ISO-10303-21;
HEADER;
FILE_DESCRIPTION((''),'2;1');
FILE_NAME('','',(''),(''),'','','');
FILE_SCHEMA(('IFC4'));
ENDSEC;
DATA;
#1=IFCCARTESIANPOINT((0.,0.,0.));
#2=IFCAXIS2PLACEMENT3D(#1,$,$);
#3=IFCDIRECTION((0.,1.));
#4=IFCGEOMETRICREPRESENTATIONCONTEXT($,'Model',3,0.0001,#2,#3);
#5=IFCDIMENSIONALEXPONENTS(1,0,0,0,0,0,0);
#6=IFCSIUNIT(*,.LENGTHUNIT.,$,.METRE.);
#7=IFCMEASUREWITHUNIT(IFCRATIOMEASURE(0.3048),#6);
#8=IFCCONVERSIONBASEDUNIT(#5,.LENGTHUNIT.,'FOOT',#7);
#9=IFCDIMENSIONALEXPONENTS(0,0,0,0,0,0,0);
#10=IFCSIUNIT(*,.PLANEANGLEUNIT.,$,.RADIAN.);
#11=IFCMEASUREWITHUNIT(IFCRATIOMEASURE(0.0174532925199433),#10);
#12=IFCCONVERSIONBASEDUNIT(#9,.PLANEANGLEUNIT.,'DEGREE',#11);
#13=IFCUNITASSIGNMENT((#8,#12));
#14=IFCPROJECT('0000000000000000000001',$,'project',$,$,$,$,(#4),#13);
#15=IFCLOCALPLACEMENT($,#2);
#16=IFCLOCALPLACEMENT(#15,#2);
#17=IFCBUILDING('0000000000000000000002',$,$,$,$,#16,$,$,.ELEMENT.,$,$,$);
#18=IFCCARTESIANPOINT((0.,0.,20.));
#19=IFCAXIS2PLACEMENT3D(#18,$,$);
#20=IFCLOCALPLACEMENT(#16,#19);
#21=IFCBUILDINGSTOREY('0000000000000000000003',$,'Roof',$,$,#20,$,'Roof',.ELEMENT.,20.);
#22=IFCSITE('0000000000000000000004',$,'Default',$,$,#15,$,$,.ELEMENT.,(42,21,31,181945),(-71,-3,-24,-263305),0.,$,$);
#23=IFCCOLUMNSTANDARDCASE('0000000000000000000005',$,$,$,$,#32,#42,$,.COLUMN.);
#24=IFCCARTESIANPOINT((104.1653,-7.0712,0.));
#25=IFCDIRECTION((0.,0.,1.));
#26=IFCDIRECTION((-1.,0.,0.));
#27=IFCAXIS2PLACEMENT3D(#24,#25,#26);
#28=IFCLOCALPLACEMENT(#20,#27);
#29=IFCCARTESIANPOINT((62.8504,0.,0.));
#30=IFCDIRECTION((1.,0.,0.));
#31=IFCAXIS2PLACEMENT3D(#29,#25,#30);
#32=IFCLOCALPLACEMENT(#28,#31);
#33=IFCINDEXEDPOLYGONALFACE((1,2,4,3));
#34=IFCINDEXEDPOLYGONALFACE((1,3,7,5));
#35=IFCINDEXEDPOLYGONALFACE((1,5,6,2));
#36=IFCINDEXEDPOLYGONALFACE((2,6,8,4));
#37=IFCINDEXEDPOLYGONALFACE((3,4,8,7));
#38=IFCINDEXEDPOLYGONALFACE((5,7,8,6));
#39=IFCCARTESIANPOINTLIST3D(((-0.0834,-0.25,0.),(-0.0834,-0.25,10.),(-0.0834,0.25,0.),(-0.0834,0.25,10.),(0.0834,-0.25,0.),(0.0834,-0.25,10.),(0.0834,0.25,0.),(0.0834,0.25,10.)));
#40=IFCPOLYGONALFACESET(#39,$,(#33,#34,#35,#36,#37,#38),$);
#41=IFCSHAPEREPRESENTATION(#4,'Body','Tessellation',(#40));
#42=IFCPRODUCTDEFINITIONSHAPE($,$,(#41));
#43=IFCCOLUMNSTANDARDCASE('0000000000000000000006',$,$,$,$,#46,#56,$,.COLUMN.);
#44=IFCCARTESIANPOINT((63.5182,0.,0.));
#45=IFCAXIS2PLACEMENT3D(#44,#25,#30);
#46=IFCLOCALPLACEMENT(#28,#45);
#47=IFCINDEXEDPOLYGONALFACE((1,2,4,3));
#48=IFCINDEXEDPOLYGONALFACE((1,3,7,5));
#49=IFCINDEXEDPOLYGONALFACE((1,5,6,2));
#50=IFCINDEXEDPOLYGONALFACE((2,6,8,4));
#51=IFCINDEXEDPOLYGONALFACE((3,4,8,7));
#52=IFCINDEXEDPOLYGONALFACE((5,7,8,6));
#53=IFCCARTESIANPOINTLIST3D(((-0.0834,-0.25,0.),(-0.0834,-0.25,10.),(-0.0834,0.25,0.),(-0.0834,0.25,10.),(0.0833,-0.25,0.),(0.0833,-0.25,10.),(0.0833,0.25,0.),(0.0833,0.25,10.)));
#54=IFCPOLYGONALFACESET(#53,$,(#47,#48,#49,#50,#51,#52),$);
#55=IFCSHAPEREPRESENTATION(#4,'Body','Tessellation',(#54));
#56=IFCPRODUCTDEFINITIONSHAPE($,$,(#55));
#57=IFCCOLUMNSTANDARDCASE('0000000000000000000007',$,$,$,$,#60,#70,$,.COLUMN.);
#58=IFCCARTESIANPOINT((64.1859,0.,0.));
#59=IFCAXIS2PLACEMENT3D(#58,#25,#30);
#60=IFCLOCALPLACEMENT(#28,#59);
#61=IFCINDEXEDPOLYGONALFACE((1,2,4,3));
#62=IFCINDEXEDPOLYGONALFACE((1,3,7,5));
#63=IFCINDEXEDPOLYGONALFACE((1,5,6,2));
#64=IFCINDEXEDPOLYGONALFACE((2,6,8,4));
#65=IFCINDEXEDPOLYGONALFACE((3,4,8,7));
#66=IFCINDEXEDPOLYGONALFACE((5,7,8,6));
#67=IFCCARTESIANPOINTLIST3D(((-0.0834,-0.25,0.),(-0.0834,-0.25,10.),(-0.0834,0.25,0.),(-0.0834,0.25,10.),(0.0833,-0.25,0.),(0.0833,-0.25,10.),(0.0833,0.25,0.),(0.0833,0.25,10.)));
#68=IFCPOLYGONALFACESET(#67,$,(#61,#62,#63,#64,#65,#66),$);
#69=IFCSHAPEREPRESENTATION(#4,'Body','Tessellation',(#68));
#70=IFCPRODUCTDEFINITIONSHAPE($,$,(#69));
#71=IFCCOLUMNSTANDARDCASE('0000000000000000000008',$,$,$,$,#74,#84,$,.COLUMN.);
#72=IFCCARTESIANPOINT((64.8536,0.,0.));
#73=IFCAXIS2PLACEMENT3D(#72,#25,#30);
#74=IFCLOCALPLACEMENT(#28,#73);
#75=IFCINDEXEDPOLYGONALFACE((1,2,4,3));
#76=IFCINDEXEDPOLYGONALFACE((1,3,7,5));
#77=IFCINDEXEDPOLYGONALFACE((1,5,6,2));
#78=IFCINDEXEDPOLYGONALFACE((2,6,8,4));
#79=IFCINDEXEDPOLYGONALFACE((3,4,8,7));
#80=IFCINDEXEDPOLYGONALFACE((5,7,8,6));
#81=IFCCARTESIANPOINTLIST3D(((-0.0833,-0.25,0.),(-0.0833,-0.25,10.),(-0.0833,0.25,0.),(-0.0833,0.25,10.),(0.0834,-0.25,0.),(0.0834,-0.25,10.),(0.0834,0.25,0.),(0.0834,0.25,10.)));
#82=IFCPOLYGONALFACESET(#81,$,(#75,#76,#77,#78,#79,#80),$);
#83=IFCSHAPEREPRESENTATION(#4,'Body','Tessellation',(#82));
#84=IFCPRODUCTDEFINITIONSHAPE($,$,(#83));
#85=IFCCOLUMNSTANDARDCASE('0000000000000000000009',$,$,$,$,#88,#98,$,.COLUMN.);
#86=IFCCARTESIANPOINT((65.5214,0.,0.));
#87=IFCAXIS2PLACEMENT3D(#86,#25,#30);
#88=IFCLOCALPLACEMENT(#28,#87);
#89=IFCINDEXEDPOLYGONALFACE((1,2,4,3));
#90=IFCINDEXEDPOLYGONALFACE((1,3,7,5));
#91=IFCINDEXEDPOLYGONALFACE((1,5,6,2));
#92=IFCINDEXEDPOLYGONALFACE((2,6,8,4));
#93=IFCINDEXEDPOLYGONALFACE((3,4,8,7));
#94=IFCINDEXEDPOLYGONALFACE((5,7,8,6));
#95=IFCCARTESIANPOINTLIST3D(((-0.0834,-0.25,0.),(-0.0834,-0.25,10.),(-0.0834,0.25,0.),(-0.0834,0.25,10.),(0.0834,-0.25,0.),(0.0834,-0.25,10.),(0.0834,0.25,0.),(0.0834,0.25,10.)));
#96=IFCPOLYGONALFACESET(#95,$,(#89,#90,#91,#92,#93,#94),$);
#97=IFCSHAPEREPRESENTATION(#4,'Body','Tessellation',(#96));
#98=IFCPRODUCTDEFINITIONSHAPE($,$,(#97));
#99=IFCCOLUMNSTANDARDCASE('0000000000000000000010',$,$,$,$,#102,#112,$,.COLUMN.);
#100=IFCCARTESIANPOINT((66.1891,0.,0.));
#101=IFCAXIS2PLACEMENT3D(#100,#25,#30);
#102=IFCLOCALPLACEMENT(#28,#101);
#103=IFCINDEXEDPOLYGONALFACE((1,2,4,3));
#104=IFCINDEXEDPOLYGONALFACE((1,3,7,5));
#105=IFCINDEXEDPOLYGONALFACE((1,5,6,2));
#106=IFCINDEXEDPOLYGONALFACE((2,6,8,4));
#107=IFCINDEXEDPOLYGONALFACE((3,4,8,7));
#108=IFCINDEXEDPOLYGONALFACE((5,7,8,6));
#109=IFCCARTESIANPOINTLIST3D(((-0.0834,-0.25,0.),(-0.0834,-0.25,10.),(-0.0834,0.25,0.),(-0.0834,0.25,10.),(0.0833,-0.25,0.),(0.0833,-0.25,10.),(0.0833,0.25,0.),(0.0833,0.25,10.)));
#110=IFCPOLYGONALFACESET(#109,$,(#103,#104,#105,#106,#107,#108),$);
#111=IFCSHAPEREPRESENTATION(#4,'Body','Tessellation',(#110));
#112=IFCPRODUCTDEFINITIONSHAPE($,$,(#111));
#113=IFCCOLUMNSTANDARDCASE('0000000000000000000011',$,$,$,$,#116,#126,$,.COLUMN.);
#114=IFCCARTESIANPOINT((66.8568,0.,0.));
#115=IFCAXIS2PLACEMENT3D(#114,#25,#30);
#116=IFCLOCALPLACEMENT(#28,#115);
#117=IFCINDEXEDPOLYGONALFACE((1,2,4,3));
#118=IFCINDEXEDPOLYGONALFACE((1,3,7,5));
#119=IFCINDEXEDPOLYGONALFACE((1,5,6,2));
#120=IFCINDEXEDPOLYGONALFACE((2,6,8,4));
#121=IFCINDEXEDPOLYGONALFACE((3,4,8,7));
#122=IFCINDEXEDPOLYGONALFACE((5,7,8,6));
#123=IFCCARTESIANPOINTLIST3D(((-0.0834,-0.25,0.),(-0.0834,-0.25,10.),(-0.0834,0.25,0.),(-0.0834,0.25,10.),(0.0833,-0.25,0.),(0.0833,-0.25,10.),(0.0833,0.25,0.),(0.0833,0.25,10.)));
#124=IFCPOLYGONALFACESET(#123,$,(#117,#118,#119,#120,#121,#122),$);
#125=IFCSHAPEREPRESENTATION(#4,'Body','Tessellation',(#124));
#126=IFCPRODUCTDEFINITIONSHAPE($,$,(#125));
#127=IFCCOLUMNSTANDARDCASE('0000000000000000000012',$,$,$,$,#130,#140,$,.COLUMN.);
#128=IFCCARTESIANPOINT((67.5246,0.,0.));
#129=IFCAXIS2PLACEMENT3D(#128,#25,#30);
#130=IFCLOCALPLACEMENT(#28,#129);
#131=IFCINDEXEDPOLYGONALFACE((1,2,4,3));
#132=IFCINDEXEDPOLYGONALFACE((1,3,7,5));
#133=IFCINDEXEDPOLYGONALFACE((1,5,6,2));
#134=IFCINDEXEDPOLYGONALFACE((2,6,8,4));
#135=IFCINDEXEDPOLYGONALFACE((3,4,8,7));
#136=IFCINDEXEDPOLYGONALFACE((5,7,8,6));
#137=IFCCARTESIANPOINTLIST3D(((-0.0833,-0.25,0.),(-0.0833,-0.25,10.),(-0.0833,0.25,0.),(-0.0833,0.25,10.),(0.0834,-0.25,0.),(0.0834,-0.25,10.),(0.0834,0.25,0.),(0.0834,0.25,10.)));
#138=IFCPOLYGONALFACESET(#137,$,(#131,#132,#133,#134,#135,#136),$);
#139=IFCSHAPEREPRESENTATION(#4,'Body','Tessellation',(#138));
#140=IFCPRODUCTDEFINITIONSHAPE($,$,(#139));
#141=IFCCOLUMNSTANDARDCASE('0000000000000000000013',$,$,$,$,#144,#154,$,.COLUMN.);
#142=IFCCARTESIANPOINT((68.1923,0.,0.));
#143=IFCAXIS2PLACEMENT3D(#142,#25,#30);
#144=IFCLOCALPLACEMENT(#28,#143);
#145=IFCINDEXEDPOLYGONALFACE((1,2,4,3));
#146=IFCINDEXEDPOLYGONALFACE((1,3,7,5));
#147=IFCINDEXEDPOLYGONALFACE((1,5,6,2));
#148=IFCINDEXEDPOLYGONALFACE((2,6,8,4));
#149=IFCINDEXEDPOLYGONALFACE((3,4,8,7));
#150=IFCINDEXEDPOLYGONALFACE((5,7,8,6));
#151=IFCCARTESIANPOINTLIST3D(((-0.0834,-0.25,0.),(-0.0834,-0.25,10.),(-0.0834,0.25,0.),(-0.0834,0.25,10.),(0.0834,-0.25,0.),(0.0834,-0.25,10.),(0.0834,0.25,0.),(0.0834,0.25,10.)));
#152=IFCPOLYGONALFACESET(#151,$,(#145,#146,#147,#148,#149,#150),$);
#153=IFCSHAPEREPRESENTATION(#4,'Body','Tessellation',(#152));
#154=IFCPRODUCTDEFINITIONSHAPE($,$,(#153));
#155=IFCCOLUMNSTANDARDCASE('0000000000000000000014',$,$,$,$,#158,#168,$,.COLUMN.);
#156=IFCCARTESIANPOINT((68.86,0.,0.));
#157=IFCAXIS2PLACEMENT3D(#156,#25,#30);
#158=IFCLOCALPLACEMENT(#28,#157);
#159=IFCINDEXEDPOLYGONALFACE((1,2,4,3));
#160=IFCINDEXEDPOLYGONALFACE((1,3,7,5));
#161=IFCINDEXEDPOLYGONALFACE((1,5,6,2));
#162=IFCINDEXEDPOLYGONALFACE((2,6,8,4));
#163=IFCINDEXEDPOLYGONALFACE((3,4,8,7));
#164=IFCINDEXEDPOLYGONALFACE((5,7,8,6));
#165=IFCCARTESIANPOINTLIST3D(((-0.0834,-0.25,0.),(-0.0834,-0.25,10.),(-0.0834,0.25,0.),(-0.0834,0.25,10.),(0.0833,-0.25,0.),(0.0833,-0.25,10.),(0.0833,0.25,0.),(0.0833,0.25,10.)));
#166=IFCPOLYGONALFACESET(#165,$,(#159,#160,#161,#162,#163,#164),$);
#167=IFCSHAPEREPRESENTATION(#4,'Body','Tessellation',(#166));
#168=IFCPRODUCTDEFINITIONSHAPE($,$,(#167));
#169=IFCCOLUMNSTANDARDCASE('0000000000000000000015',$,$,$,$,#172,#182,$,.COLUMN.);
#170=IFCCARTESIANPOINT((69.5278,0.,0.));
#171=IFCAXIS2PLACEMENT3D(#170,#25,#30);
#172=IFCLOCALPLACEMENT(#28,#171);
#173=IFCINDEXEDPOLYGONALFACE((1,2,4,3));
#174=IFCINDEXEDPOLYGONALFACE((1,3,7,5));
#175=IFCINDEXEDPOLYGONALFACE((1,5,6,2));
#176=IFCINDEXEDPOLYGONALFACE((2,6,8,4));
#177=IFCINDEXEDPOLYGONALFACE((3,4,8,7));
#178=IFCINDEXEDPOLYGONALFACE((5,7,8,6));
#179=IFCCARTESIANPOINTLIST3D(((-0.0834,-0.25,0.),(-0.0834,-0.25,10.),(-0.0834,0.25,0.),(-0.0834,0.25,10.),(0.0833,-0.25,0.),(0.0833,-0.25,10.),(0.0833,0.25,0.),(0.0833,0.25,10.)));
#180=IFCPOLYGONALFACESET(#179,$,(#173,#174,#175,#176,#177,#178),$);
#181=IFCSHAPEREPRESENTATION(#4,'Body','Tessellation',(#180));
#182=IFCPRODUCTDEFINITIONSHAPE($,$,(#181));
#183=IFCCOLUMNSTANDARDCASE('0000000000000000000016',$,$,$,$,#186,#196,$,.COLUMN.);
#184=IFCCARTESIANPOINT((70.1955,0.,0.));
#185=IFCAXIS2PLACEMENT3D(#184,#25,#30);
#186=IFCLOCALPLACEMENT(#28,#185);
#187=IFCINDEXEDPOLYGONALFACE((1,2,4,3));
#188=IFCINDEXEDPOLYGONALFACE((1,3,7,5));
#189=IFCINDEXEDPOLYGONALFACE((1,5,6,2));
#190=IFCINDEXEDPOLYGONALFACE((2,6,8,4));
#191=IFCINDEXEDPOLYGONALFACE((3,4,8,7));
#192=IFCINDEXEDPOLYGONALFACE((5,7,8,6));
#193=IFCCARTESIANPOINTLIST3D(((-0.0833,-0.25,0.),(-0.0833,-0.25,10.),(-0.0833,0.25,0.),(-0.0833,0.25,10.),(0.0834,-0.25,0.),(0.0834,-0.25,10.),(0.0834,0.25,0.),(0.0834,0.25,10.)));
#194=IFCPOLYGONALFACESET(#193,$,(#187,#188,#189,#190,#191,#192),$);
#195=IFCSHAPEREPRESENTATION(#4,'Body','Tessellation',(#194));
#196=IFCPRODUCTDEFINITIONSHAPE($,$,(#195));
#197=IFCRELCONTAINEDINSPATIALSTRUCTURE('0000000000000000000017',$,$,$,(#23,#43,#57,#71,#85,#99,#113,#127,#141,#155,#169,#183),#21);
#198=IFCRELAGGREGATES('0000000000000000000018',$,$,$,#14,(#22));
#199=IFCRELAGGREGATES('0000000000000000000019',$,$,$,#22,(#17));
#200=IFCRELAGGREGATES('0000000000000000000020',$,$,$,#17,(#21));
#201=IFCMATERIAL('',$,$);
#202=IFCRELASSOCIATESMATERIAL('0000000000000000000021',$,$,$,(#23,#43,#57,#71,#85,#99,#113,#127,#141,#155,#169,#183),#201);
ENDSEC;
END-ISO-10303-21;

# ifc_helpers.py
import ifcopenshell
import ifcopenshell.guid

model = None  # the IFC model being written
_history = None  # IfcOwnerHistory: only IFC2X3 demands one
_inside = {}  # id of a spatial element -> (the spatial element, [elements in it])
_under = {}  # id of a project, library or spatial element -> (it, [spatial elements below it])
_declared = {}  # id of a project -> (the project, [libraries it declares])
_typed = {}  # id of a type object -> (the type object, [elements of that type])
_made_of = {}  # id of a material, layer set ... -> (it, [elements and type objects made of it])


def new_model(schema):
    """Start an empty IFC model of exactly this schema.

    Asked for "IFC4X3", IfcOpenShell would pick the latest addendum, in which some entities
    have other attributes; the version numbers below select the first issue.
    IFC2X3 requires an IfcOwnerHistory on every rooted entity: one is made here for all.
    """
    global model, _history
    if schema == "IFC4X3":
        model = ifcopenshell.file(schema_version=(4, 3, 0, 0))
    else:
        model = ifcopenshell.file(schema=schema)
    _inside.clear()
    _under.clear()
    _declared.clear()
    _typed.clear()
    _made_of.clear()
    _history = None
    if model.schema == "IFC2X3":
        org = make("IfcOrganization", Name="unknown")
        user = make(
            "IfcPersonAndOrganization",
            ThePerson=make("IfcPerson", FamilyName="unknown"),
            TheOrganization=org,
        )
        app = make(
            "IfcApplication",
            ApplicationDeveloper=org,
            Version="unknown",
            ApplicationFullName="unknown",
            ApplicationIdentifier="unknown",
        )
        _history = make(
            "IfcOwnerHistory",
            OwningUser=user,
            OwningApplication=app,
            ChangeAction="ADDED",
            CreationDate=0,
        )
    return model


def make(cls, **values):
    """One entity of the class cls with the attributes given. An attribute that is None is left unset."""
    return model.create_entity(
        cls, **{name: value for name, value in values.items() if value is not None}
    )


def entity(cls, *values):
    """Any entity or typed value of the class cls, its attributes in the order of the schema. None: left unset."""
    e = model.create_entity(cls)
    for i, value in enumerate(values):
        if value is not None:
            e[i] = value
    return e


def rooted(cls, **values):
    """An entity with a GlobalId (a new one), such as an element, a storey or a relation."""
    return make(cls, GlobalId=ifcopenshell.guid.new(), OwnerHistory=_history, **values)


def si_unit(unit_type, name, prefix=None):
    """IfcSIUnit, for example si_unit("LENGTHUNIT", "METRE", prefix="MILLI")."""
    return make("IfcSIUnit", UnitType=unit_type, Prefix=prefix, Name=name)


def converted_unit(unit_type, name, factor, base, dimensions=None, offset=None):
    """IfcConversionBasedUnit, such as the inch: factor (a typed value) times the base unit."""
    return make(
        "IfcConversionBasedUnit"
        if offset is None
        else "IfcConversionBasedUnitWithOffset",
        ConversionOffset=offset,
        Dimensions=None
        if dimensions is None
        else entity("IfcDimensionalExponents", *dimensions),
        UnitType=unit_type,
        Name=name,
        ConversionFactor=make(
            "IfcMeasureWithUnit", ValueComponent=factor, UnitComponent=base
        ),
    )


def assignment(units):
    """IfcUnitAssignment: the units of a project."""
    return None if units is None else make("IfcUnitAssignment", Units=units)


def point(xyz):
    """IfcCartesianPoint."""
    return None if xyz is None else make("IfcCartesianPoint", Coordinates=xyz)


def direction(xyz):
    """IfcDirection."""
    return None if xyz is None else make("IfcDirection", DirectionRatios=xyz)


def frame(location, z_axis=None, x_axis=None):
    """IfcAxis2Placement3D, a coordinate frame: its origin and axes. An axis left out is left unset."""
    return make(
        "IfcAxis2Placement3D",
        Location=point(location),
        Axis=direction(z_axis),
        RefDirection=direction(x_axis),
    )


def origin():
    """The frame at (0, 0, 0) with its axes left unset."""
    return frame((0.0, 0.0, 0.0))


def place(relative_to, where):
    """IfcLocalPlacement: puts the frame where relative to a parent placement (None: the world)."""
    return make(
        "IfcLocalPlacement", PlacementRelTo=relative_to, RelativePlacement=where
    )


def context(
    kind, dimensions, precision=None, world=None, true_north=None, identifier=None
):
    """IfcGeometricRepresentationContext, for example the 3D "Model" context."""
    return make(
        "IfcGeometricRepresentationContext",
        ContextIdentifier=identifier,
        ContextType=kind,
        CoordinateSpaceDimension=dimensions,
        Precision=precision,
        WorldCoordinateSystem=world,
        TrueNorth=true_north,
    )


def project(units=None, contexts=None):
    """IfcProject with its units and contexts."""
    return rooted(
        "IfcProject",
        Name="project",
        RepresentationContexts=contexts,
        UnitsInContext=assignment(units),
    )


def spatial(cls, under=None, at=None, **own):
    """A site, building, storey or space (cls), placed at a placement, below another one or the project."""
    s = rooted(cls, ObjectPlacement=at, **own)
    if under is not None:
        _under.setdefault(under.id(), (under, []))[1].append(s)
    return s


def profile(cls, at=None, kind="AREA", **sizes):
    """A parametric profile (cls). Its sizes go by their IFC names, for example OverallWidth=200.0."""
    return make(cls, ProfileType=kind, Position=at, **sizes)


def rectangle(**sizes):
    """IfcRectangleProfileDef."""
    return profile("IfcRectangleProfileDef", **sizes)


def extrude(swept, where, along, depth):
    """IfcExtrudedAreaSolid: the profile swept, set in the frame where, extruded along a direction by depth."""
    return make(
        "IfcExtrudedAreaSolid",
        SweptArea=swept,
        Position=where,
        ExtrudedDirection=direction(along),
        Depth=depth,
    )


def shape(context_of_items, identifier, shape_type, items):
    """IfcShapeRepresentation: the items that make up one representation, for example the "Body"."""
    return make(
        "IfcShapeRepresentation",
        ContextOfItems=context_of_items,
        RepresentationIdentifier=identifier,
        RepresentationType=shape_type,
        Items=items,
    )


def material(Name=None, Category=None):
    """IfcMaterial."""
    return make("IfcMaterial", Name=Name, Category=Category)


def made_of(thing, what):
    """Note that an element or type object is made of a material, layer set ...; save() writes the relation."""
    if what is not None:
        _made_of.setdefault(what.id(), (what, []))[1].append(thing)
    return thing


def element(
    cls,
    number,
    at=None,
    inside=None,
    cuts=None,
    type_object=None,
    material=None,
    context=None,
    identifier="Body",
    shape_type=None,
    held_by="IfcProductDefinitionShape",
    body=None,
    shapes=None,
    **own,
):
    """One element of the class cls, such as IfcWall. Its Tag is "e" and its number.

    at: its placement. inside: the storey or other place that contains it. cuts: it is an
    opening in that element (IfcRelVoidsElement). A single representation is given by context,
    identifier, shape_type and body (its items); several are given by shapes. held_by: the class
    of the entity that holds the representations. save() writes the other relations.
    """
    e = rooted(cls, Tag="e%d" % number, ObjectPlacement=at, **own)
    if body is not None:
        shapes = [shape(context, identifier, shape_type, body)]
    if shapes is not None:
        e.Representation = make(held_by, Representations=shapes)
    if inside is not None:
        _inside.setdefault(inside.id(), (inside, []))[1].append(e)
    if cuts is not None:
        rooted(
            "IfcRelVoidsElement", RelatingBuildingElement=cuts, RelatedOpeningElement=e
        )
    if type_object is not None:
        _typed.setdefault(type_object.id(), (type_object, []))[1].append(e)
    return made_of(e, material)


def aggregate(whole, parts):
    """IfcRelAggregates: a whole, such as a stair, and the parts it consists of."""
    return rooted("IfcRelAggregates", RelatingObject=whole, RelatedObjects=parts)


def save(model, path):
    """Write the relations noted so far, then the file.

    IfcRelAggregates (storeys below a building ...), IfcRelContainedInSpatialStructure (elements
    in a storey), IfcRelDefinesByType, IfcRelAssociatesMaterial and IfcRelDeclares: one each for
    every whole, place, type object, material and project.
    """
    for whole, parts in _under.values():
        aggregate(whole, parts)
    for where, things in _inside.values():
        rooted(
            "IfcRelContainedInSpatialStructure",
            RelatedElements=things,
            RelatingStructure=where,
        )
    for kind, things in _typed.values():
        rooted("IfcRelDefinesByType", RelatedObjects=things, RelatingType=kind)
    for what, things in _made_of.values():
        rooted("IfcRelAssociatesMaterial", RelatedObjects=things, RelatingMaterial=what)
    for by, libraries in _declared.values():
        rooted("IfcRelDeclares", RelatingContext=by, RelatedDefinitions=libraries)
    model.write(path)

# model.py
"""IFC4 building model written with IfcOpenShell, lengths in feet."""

from ifc_helpers import new_model, entity, si_unit, converted_unit, direction, frame, origin, place, context, project, spatial, rectangle, extrude, material, element, save


model = new_model("IFC4")

# Units and contexts
model_context = context("Model", 3, precision=0.0001, world=origin(), true_north=direction((0.0, 1.0)))
ifc_project = project(units=[converted_unit("LENGTHUNIT", "FOOT", entity("IfcRatioMeasure", 0.3048), si_unit("LENGTHUNIT", "METRE"), dimensions=[1, 0, 0, 0, 0, 0, 0]), converted_unit("PLANEANGLEUNIT", "DEGREE", entity("IfcRatioMeasure", 0.0174532925199433), si_unit("PLANEANGLEUNIT", "RADIAN"), dimensions=[0, 0, 0, 0, 0, 0, 0])], contexts=[model_context])

# Site, building, storey
site_placement = place(None, origin())
site = spatial("IfcSite", under=ifc_project, at=site_placement, Name="Default", CompositionType="ELEMENT", RefLatitude=(42, 21, 31, 181945), RefLongitude=(-71, -3, -24, -263305), RefElevation=0.0)
building_placement = place(site_placement, origin())
building = spatial("IfcBuilding", under=site, at=building_placement, CompositionType="ELEMENT")
storey_placement = place(building_placement, frame((0.0, 0.0, 20.0)))
storey = spatial("IfcBuildingStorey", under=building, at=storey_placement, Name="Roof", LongName="Roof", CompositionType="ELEMENT", Elevation=20.0)

# Columns
ifc_material = material(Name="")
placement = place(storey_placement, frame((104.1653, -7.0712, 0.0), z_axis=(0.0, 0.0, 1.0), x_axis=(-1.0, 0.0, 0.0)))
for number, where, z_axis, x_axis in (
    (1, (62.8504, 0.0, 0.0), (0.0, 0.0, 1.0), (1.0, 0.0, 0.0)),
    (2, (63.5182, 0.0, 0.0), (0.0, 0.0, 1.0), (1.0, 0.0, 0.0)),
    (3, (64.1859, 0.0, 0.0), (0.0, 0.0, 1.0), (1.0, 0.0, 0.0)),
    (4, (64.8536, 0.0, 0.0), (0.0, 0.0, 1.0), (1.0, 0.0, 0.0)),
    (5, (65.5214, 0.0, 0.0), (0.0, 0.0, 1.0), (1.0, 0.0, 0.0)),
    (6, (66.1891, 0.0, 0.0), (0.0, 0.0, 1.0), (1.0, 0.0, 0.0)),
    (7, (66.8568, 0.0, 0.0), (0.0, 0.0, 1.0), (1.0, 0.0, 0.0)),
    (8, (67.5246, 0.0, 0.0), (0.0, 0.0, 1.0), (1.0, 0.0, 0.0)),
    (9, (68.1923, 0.0, 0.0), (0.0, 0.0, 1.0), (1.0, 0.0, 0.0)),
    (10, (68.86, 0.0, 0.0), (0.0, 0.0, 1.0), (1.0, 0.0, 0.0)),
    (11, (69.5278, 0.0, 0.0), (0.0, 0.0, 1.0), (1.0, 0.0, 0.0)),
    (12, (70.1955, 0.0, 0.0), (0.0, 0.0, 1.0), (1.0, 0.0, 0.0)),
):
    element("IfcColumnStandardCase", number, at=place(placement, frame(where, z_axis=z_axis, x_axis=x_axis)), inside=storey, material=ifc_material, PredefinedType="COLUMN", context=model_context, shape_type="SweptSolid", body=[
        extrude(rectangle(XDim=0.1667, YDim=0.5), origin(), (0.0, 0.0, 1.0), 10.0),
    ])

save(model, "model.ifc")
